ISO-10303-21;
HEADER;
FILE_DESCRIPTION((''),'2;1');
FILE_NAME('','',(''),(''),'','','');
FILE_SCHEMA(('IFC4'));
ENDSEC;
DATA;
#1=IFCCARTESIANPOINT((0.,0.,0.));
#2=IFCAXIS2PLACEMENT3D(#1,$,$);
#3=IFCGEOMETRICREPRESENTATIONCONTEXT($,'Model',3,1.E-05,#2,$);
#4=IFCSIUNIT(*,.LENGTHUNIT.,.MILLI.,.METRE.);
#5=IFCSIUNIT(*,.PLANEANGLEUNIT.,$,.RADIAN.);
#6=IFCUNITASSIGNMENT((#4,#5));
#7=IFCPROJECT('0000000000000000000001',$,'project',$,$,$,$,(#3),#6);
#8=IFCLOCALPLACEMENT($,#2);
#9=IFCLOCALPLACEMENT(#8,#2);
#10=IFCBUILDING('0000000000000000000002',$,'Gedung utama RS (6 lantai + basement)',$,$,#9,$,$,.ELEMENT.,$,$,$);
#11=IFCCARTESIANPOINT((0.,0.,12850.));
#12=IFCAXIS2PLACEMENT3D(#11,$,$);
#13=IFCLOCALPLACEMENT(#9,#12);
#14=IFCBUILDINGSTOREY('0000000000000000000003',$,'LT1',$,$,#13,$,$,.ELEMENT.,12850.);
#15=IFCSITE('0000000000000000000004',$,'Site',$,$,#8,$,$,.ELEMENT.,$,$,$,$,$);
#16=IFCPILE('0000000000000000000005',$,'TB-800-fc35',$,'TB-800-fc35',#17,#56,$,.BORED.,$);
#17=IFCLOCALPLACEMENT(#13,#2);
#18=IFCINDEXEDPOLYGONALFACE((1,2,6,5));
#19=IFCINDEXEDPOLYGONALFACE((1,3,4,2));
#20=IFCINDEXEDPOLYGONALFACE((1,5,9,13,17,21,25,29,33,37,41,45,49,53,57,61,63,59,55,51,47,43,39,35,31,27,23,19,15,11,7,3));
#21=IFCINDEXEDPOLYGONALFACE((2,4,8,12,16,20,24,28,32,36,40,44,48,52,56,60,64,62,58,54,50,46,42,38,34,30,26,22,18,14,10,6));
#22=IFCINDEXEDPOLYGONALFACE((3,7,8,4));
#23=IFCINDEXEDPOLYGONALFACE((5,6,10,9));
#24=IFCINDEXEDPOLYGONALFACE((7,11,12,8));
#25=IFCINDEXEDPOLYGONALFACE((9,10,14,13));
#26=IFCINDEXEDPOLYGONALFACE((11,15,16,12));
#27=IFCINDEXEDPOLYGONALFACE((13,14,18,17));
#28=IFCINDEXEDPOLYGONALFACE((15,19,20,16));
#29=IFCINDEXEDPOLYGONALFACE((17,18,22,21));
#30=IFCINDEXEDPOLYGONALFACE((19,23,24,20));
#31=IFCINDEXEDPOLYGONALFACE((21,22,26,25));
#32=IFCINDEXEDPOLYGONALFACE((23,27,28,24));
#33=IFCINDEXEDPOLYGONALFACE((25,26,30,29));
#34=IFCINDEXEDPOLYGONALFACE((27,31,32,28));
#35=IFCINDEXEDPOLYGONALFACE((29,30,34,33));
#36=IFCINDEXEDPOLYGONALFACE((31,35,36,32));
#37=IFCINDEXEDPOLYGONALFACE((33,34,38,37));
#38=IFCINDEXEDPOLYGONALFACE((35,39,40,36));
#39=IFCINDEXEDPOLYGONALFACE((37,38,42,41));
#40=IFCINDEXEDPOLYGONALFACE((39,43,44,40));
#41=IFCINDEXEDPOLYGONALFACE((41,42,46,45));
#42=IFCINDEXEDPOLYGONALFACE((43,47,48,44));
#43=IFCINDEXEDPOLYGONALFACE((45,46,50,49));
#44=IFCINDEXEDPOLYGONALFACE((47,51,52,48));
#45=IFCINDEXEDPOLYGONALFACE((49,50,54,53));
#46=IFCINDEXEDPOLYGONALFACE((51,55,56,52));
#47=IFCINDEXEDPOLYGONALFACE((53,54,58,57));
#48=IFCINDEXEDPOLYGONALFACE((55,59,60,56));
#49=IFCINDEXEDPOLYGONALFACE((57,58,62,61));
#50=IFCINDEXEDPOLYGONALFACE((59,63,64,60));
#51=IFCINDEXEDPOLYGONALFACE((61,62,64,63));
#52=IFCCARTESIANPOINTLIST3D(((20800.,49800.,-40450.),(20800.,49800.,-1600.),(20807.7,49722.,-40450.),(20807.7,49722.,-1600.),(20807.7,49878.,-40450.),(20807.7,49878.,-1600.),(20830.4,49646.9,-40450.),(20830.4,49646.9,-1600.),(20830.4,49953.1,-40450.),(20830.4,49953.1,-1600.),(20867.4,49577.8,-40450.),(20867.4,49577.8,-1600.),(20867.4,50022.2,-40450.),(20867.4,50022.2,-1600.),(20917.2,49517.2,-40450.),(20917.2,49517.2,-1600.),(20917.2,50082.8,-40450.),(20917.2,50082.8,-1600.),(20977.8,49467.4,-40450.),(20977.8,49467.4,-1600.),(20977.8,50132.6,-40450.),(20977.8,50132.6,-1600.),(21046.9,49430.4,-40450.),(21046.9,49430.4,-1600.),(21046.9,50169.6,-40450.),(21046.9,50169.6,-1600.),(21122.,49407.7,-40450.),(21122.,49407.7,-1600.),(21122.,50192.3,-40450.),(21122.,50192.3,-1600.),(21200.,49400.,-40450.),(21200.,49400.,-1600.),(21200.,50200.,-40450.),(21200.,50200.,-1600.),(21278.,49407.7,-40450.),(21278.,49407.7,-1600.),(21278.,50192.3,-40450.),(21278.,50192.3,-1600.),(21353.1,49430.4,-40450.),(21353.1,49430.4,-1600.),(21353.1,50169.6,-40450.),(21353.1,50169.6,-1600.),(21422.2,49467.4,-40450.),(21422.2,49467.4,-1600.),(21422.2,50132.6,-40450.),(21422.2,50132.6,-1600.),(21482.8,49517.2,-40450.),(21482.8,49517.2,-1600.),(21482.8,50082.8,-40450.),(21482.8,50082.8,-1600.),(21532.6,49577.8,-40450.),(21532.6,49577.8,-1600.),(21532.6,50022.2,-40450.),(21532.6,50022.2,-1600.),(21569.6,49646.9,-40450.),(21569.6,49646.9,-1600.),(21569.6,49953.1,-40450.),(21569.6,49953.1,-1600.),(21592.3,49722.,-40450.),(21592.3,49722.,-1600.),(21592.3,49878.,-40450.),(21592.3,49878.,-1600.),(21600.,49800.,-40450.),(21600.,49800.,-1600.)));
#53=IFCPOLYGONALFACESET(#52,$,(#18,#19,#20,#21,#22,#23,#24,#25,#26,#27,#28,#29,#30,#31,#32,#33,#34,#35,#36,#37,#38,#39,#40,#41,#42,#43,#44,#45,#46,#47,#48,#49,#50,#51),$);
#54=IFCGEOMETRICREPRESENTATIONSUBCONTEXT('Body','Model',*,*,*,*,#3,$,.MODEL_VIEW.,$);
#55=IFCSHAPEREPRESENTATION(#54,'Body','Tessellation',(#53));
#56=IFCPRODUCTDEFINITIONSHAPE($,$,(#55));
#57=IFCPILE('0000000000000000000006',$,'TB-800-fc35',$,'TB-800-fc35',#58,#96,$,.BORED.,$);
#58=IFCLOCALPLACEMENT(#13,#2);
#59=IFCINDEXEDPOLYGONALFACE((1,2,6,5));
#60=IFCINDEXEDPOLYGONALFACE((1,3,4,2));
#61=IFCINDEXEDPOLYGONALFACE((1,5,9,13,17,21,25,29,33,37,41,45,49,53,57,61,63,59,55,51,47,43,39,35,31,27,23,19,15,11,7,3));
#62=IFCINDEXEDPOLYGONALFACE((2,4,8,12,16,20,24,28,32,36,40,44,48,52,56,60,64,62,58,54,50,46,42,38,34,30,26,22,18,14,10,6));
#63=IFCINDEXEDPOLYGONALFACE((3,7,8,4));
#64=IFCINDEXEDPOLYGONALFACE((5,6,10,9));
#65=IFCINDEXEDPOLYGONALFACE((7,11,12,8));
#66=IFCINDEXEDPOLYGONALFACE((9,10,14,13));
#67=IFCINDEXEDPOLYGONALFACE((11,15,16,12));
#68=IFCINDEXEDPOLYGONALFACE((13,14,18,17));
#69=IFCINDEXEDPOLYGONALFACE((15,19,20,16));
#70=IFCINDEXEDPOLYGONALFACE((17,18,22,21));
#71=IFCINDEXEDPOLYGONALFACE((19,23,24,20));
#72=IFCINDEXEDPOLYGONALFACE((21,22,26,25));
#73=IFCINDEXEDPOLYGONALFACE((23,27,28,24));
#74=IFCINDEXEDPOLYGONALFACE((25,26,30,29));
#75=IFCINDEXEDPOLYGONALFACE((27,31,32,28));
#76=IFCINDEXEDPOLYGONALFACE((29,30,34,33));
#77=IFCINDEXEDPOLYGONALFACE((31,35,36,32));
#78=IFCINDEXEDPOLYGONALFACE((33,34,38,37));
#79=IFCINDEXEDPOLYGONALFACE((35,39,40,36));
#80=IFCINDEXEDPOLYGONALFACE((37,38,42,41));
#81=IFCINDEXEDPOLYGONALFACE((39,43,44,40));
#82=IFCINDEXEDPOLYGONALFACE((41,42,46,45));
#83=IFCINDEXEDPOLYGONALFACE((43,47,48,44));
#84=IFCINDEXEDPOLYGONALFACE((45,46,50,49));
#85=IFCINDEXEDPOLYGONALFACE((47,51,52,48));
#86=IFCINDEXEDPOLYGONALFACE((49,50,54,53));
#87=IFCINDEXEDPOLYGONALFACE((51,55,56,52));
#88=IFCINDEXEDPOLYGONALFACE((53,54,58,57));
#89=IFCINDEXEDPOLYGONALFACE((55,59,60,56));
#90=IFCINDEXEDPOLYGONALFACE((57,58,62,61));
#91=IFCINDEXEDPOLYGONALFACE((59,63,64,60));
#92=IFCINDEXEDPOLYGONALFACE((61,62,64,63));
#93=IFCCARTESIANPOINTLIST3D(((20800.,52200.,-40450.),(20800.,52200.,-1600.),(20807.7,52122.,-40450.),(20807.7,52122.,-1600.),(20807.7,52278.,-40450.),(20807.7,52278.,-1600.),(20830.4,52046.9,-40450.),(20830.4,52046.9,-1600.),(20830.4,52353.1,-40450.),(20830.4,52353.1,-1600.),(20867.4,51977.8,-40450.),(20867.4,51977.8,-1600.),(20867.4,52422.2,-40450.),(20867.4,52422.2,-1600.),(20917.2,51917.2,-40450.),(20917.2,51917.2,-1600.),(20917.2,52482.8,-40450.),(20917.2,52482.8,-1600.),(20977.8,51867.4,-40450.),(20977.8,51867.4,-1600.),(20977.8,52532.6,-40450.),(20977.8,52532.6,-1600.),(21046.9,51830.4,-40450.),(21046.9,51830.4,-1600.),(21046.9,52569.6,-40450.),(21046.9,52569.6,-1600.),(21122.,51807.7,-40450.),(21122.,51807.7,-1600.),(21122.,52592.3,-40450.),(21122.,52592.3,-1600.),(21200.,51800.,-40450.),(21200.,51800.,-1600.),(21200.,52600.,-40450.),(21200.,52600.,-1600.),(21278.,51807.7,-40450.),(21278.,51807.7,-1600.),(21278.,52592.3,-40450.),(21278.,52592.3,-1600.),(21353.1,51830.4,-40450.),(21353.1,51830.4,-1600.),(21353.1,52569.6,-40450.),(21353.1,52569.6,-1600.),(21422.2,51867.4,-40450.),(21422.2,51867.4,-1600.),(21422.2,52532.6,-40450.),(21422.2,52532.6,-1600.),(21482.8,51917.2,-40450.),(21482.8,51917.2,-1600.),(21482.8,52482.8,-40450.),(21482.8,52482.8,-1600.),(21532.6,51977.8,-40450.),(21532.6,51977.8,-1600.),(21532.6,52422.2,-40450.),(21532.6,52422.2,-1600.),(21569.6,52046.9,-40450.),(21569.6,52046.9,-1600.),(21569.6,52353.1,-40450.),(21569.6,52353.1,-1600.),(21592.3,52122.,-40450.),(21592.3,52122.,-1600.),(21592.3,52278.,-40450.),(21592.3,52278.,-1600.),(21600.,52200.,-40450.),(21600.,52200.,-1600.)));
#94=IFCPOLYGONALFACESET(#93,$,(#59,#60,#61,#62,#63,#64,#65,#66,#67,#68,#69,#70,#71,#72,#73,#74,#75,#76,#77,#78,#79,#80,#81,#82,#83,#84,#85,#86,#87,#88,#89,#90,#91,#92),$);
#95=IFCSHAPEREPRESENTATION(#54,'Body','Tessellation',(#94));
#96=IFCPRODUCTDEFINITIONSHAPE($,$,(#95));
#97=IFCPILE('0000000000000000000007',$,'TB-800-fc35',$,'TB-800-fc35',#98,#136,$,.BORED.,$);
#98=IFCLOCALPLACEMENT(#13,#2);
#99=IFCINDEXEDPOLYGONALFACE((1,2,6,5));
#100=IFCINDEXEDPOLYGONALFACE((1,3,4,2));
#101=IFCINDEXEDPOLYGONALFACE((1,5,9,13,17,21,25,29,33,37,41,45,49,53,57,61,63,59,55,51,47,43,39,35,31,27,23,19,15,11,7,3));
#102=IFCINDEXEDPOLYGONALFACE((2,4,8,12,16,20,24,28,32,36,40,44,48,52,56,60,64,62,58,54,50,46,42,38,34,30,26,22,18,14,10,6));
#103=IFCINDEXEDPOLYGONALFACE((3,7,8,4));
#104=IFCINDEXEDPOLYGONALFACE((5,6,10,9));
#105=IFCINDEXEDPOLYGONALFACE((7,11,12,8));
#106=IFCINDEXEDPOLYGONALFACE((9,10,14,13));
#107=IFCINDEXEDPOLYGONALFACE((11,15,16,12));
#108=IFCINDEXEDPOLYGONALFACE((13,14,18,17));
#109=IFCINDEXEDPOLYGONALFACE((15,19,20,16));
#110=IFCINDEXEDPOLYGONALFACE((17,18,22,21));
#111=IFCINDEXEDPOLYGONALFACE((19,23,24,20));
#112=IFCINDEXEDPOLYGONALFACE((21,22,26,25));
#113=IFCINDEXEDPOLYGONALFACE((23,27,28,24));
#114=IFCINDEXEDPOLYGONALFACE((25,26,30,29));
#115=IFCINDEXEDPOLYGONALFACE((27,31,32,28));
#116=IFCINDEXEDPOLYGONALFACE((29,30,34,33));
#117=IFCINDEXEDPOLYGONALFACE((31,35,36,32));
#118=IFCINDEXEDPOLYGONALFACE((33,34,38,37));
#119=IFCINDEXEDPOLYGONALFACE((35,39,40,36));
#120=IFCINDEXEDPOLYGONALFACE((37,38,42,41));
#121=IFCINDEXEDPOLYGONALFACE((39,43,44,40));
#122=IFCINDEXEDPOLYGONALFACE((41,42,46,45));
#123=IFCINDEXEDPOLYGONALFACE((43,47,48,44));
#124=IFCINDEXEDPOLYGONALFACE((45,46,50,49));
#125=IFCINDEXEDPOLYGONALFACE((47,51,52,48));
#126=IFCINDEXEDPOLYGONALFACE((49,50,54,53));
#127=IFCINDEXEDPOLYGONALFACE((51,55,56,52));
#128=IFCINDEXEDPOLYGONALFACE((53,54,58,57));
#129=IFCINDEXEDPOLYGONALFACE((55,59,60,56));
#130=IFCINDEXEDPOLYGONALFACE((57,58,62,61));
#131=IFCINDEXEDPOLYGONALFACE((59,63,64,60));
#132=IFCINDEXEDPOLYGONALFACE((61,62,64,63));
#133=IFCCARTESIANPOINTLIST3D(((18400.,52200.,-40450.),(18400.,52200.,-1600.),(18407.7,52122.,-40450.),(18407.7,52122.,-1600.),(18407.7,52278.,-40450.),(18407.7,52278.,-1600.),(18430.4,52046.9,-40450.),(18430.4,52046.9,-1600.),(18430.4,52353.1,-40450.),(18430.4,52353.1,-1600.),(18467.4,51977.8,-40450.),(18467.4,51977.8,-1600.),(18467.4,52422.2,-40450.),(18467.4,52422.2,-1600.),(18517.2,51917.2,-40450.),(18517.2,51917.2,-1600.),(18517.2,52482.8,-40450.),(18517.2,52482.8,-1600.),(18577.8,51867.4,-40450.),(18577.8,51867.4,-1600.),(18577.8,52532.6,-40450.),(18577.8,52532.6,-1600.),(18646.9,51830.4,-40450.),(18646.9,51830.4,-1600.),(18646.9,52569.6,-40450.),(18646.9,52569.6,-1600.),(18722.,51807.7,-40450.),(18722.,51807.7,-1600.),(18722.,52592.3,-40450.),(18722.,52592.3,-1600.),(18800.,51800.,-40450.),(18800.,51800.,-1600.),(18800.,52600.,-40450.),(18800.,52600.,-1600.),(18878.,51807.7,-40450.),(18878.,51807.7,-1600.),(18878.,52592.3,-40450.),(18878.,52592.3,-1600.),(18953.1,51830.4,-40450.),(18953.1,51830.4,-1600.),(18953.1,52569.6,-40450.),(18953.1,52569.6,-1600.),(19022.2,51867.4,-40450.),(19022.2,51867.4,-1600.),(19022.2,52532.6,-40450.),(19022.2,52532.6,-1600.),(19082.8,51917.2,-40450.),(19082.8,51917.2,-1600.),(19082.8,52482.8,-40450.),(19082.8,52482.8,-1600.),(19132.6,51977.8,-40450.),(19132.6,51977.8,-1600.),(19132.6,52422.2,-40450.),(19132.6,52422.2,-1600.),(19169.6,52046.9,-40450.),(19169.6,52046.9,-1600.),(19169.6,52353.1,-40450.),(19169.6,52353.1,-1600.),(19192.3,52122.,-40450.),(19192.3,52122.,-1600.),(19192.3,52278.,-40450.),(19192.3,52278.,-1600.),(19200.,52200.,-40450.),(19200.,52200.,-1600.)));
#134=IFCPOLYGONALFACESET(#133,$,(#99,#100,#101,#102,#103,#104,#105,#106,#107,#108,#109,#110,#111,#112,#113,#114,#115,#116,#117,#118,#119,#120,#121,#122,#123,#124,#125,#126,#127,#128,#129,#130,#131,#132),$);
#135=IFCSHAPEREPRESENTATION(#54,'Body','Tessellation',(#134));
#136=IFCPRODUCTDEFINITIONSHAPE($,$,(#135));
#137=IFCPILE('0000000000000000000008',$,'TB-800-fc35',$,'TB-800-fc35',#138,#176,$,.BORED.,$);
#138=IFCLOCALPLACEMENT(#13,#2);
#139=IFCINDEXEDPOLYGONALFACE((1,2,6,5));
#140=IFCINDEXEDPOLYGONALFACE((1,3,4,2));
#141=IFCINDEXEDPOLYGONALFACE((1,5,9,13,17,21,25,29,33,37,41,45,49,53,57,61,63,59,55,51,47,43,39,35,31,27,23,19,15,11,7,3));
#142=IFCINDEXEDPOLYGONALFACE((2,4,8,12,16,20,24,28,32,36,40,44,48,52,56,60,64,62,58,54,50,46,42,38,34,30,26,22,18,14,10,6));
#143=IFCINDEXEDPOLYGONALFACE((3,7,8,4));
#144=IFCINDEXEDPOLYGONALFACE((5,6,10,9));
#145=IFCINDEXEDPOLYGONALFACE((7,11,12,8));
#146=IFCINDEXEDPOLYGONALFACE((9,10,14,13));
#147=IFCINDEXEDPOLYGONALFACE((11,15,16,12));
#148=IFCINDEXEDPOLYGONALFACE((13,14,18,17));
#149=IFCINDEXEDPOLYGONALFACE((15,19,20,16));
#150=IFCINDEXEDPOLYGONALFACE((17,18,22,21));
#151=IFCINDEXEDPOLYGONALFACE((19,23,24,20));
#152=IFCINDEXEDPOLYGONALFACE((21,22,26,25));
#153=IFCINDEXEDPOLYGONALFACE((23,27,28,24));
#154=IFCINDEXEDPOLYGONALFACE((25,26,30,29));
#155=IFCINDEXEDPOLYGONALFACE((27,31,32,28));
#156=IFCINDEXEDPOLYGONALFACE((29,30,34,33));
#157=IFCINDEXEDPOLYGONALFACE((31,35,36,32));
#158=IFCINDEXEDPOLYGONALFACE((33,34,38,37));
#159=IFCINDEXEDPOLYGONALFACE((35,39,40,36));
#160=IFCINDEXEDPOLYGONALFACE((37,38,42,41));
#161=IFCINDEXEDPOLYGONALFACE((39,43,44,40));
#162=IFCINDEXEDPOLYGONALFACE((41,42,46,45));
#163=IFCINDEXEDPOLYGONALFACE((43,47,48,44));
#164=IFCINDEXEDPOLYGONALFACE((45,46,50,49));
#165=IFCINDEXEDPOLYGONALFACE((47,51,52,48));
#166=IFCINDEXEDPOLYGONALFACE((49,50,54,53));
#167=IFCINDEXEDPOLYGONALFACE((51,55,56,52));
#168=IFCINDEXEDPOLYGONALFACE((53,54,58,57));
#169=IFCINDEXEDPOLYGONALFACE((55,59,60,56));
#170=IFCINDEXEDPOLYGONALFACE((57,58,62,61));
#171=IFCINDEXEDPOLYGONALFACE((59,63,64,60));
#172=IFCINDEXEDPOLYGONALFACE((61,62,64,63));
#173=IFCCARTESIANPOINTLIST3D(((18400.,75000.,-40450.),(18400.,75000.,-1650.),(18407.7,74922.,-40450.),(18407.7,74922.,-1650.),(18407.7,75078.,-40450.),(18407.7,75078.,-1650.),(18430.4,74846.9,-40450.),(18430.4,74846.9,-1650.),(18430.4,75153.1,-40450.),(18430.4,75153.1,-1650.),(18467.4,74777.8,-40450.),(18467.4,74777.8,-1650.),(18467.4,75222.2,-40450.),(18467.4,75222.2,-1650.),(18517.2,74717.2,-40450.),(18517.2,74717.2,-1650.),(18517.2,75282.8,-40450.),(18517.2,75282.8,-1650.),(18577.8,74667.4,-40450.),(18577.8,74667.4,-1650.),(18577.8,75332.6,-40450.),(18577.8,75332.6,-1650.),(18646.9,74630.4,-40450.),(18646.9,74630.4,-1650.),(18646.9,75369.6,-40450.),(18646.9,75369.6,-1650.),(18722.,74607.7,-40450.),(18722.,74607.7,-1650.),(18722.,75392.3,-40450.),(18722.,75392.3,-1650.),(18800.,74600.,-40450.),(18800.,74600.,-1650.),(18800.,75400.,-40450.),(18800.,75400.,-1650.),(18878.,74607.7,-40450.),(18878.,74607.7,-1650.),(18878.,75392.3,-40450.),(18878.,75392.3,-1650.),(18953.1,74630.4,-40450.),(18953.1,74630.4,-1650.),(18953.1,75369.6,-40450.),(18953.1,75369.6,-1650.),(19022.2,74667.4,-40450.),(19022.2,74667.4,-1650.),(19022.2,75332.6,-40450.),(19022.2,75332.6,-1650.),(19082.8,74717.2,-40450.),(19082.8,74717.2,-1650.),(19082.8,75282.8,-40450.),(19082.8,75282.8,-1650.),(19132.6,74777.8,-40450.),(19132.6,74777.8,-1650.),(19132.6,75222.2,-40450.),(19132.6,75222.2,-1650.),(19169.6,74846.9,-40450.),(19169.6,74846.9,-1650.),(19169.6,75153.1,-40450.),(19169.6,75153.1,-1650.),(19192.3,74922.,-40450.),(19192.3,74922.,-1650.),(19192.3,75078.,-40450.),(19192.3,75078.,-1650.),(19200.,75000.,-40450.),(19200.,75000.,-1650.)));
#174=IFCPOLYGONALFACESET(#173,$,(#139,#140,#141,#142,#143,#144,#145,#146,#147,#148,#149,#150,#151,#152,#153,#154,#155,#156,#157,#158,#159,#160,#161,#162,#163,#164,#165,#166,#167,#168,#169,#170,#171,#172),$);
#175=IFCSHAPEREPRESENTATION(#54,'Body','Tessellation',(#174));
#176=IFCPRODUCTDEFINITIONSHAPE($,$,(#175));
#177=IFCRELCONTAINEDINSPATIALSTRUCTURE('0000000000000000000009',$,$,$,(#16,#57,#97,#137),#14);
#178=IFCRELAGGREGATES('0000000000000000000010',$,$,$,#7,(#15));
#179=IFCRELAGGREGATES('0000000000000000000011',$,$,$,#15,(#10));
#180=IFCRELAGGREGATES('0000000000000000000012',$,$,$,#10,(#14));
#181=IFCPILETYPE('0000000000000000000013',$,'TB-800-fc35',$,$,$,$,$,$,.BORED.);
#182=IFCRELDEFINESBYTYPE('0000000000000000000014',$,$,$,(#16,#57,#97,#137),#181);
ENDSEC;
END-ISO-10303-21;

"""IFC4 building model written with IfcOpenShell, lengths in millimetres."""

from ifc_helpers import new_model, si_unit, frame, origin, origin_2d, place, context, subcontext, project, spatial, circle, extrude, material_profile, profile_set, profile_usage, type_object, element, save


model = new_model("IFC4")

# Units and contexts
model_context = context("Model", 3, precision=1e-05, world=origin())
body_context = subcontext(model_context, "Body", "Model", "MODEL_VIEW")
ifc_project = project(units=[si_unit("LENGTHUNIT", "METRE", prefix="MILLI"), si_unit("PLANEANGLEUNIT", "RADIAN")], contexts=[model_context])

# Site, building, storey
site_placement = place(None, origin())
site = spatial("IfcSite", under=ifc_project, at=site_placement, Name="Site", CompositionType="ELEMENT")
building_placement = place(site_placement, origin())
building = spatial("IfcBuilding", under=site, at=building_placement, Name="Gedung utama RS (6 lantai + basement)", CompositionType="ELEMENT")
storey_placement = place(building_placement, frame((0.0, 0.0, 12850.0)))
storey = spatial("IfcBuildingStorey", under=building, at=storey_placement, Name="LT1", CompositionType="ELEMENT", Elevation=12850.0)

# Piles
ifc_material_profile = material_profile(None, circle(Radius=400.0, at=origin_2d()), Name="TB-800-fc35")
ifc_profile_set = profile_set([ifc_material_profile], Name="TB-800-fc35")
ifc_profile_usage = profile_usage(ifc_profile_set, cardinal=5)
pile_type = type_object("IfcPileType", Name="TB-800-fc35", PredefinedType="BORED", material=ifc_profile_set)
for number, where, z_axis, x_axis, name in (
    (1, (21200.0, 49800.0, -40450.0), (0.0, 0.0, 1.0), (1.0, 0.0, 0.0), "TB-800-fc35"),
    (2, (21200.0, 52200.0, -40450.0), (0.0, 0.0, 1.0), (1.0, 0.0, 0.0), "TB-800-fc35"),
    (3, (18800.0, 52200.0, -40450.0), (0.0, 0.0, 1.0), (1.0, 0.0, 0.0), "TB-800-fc35"),
):
    element("IfcPile", number, at=place(storey_placement, frame(where, z_axis=z_axis, x_axis=x_axis)), inside=storey, type_object=pile_type, material=ifc_profile_usage, Name=name, ObjectType="TB-800-fc35", PredefinedType="BORED", context=body_context, shape_type="SweptSolid", body=[
        extrude(circle(Radius=400.0, at=origin_2d()), origin(), (0.0, 0.0, 1.0), 38850.0),
    ])
for number, where, z_axis, x_axis, name in (
    (4, (18800.0, 75000.0, -40450.0), (0.0, 0.0, 1.0), (1.0, 0.0, 0.0), "TB-800-fc35"),
):
    element("IfcPile", number, at=place(storey_placement, frame(where, z_axis=z_axis, x_axis=x_axis)), inside=storey, type_object=pile_type, material=ifc_profile_usage, Name=name, ObjectType="TB-800-fc35", PredefinedType="BORED", context=body_context, shape_type="SweptSolid", body=[
        extrude(circle(Radius=400.0, at=origin_2d()), origin(), (0.0, 0.0, 1.0), 38800.0),
    ])

save(model, "model.ifc")
